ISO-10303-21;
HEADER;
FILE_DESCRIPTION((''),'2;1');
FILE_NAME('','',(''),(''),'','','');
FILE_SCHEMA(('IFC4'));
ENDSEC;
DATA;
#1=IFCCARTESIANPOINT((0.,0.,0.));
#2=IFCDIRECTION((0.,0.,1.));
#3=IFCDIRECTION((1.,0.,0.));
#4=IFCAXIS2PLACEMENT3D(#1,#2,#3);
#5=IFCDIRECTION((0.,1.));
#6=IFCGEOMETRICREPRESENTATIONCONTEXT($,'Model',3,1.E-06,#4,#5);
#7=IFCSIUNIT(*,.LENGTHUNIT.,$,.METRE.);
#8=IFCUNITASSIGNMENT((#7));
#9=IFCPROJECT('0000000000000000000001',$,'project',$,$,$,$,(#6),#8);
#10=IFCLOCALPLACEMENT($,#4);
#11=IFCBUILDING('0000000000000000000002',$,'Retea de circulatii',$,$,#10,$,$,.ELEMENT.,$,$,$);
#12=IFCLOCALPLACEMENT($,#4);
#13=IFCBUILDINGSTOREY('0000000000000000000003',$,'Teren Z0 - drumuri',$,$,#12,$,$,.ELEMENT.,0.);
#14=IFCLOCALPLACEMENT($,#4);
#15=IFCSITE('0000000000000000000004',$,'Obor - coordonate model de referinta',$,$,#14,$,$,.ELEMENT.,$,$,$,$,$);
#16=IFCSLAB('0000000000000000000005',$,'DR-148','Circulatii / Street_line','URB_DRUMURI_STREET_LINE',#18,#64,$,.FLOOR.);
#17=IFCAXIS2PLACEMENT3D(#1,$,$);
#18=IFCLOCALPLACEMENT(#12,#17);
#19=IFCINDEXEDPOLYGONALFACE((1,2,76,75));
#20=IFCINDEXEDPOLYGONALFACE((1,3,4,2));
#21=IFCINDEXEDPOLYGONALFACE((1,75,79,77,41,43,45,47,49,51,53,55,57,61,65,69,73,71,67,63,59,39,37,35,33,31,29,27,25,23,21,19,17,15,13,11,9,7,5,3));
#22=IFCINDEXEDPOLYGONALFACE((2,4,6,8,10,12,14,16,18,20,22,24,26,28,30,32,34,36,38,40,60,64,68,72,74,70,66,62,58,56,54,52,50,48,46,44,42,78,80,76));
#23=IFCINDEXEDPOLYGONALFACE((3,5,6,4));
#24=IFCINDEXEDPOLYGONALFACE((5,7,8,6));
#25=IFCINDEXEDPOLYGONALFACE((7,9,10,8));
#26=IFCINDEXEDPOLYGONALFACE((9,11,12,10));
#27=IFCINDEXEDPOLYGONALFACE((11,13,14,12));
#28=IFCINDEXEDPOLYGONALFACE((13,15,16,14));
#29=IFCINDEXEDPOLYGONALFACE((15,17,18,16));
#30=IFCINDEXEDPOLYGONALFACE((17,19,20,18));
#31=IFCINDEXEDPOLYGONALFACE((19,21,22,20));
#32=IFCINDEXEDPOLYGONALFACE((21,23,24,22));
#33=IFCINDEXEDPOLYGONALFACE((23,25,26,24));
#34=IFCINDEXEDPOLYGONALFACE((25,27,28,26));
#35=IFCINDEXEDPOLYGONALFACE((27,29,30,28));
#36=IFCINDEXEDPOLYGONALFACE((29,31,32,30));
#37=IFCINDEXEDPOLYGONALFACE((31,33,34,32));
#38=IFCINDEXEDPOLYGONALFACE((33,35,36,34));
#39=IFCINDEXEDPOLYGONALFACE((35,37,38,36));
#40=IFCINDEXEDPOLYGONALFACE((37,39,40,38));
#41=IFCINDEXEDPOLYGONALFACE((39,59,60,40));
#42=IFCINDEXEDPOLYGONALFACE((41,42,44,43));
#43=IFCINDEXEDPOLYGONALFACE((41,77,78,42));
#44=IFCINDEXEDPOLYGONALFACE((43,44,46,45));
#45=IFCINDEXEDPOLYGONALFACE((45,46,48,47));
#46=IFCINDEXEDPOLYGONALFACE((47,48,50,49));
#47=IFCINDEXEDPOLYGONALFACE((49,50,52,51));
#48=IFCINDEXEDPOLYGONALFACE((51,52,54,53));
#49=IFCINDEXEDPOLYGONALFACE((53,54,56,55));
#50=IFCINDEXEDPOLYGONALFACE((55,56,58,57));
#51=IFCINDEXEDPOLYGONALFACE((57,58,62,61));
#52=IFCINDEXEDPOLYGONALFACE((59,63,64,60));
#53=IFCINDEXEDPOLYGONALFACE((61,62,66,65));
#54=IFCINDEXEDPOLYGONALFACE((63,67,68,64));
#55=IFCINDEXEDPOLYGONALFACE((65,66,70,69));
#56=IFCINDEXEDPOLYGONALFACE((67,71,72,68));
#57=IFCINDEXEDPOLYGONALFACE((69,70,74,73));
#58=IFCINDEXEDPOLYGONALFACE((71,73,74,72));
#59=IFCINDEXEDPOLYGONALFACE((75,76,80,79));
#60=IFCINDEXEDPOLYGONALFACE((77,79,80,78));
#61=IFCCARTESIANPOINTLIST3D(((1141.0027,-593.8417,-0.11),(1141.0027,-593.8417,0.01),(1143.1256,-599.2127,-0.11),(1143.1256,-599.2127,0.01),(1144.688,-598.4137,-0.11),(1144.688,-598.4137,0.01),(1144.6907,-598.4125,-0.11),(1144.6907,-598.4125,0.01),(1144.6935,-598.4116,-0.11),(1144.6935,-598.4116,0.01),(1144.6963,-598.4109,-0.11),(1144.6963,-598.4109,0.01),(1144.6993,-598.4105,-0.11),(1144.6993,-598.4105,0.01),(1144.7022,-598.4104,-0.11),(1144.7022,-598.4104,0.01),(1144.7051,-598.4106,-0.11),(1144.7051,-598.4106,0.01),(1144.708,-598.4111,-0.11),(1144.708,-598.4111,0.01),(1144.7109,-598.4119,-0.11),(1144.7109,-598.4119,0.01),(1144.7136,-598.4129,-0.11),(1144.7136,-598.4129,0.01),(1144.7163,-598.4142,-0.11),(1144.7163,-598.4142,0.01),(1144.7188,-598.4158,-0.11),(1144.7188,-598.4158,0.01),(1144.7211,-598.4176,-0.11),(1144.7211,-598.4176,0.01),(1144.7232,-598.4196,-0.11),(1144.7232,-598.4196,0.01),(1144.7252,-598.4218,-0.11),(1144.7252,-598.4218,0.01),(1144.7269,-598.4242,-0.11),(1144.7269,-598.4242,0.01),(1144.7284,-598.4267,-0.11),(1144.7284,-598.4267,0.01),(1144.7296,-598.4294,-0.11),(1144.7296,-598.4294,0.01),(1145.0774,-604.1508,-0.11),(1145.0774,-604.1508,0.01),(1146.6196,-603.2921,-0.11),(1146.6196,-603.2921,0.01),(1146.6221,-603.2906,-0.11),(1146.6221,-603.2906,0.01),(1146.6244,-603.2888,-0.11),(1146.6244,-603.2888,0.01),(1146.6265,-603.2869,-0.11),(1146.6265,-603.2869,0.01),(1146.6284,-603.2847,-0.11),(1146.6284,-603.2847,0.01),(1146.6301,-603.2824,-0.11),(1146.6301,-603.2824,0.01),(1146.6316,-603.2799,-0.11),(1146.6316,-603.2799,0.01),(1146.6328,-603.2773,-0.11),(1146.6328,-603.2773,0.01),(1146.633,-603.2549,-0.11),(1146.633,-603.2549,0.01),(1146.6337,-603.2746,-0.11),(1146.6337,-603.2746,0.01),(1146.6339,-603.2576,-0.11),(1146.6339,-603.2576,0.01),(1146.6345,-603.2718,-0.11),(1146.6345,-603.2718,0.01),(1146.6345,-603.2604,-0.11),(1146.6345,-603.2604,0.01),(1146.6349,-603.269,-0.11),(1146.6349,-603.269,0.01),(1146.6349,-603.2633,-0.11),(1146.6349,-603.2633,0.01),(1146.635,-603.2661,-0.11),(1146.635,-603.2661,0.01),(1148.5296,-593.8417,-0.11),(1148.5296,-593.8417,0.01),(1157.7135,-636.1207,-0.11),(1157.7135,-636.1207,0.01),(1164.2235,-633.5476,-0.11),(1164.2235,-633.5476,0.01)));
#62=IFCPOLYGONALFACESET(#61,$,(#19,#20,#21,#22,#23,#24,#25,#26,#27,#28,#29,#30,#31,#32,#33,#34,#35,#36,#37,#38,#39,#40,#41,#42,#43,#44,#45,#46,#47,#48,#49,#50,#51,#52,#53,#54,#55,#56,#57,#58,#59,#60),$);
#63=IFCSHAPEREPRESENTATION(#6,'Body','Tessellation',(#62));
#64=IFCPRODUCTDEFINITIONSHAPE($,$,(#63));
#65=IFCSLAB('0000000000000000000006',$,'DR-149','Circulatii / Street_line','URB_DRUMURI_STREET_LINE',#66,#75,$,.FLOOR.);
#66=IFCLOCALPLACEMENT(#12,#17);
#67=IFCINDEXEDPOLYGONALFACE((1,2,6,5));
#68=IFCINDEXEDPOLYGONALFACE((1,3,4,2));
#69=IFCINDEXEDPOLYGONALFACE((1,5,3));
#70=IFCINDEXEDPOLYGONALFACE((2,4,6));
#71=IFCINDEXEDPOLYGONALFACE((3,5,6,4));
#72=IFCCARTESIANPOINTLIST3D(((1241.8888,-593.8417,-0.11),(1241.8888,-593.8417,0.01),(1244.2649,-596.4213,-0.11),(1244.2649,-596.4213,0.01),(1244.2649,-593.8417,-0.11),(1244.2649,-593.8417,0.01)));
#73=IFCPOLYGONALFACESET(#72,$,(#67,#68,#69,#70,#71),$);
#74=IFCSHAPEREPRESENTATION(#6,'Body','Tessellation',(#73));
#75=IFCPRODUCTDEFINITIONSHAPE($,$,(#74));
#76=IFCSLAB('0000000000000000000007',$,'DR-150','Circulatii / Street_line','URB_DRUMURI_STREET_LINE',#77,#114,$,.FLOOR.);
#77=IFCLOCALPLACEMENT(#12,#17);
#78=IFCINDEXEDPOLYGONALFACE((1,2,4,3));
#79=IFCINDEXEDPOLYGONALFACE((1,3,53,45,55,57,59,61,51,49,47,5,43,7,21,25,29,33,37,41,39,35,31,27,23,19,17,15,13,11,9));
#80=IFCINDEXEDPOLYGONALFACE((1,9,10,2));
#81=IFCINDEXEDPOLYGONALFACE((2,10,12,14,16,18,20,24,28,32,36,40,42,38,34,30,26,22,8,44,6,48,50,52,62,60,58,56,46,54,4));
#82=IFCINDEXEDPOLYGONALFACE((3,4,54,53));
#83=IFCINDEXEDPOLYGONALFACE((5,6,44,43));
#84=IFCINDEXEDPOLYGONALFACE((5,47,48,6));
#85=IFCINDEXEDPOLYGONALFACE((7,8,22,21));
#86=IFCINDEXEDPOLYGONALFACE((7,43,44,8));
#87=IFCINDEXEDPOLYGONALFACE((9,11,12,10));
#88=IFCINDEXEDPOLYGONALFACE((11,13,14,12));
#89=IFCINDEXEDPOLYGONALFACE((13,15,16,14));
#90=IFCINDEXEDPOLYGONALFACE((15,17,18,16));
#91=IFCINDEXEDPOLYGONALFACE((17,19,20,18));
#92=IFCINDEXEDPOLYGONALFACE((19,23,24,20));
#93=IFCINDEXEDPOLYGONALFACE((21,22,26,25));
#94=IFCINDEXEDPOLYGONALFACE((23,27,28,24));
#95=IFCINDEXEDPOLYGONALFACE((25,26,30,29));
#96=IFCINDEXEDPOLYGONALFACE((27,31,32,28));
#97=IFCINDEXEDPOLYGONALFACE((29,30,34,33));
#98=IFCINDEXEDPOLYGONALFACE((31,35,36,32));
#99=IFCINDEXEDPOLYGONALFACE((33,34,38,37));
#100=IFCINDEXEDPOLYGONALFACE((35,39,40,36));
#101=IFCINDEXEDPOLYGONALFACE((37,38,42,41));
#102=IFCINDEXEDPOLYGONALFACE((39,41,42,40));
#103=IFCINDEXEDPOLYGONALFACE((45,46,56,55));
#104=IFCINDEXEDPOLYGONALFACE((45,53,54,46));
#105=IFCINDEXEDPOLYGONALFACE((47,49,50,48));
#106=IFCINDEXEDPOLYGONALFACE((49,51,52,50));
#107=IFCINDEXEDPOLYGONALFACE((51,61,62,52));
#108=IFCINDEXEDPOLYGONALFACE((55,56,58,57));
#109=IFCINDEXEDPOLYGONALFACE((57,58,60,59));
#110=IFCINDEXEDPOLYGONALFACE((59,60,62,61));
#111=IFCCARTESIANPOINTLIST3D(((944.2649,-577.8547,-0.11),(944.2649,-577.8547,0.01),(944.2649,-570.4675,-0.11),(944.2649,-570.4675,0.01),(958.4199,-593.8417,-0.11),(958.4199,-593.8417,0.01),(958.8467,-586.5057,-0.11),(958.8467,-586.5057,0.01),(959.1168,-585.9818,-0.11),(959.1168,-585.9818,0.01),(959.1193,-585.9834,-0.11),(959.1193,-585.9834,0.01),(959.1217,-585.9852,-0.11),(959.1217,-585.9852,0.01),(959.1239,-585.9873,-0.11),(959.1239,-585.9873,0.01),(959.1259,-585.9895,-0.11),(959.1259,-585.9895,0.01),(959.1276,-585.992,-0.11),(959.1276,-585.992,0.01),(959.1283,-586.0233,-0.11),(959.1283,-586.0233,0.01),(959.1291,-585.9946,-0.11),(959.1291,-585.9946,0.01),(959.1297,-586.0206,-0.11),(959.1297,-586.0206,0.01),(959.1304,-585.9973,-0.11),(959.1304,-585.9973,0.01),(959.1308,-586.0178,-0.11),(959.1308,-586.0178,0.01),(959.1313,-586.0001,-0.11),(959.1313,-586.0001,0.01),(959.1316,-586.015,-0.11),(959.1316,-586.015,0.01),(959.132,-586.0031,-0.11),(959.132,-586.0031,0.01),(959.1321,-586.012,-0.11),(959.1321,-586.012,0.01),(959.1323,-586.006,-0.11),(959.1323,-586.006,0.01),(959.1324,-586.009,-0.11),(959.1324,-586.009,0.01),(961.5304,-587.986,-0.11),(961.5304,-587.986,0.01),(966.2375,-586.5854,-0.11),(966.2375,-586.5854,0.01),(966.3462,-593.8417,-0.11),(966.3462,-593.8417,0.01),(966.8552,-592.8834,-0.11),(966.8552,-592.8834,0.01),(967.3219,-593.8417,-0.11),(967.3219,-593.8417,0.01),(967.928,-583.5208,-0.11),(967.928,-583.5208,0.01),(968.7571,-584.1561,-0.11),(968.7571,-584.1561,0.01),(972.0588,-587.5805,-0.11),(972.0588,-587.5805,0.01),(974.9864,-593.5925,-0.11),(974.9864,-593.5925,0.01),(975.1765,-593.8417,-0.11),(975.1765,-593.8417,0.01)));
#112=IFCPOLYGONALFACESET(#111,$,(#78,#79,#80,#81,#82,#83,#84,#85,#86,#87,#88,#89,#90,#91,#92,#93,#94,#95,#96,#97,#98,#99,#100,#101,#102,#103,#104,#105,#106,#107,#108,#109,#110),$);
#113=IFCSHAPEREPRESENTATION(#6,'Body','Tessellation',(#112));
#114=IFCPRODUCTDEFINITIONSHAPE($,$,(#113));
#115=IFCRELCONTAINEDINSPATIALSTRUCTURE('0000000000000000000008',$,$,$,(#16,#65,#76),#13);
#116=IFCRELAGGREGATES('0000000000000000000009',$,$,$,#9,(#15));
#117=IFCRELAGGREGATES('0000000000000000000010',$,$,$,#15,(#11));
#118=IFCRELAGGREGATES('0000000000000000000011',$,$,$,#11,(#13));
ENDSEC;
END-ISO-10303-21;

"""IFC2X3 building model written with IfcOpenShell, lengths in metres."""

from ifc_helpers import new_model, si_unit, direction, frame, origin_with_axes, place, context, project, spatial, polyline, outline, extrude, element, save


model = new_model("IFC2X3")

# Units and contexts
model_context = context("Model", 3, precision=1e-06, world=origin_with_axes(), true_north=direction((0.0, 1.0)))
ifc_project = project(units=[si_unit("LENGTHUNIT", "METRE")], contexts=[model_context])

# Site, building, storey
site_placement = place(None, origin_with_axes())
site = spatial("IfcSite", under=ifc_project, at=site_placement, Name="Obor - coordonate model de referinta", CompositionType="ELEMENT")
building_placement = place(None, origin_with_axes())
building = spatial("IfcBuilding", under=site, at=building_placement, Name="Retea de circulatii", CompositionType="ELEMENT")
storey_placement = place(None, origin_with_axes())
storey = spatial("IfcBuildingStorey", under=building, at=storey_placement, Name="Teren Z0 - drumuri", CompositionType="ELEMENT", Elevation=0.0)

# Slabs
slab_1_placement = place(None, origin_with_axes())
element("IfcSlab", 1, at=slab_1_placement, inside=storey, Name="DR-148", Description="Circulatii / Street_line", ObjectType="URB_DRUMURI_STREET_LINE", PredefinedType="FLOOR", context=model_context, shape_type="SweptSolid", body=[
    extrude(outline(polyline([(1146.6221, -603.2906), (1146.6196, -603.2921), (1145.0774, -604.1508), (1157.7135, -636.1207), (1164.2235, -633.5476), (1148.5296, -593.8417), (1141.0027, -593.8417), (1143.1256, -599.2127), (1144.688, -598.4137), (1144.6907, -598.4125), (1144.6935, -598.4116), (1144.6963, -598.4109), (1144.6993, -598.4105), (1144.7022, -598.4104), (1144.7051, -598.4106), (1144.708, -598.4111), (1144.7109, -598.4119), (1144.7136, -598.4129), (1144.7163, -598.4142), (1144.7188, -598.4158), (1144.7211, -598.4176), (1144.7232, -598.4196), (1144.7252, -598.4218), (1144.7269, -598.4242), (1144.7284, -598.4267), (1144.7296, -598.4294), (1146.633, -603.2549), (1146.6339, -603.2576), (1146.6345, -603.2604), (1146.6349, -603.2633), (1146.635, -603.2661), (1146.6349, -603.269), (1146.6345, -603.2718), (1146.6337, -603.2746), (1146.6328, -603.2773), (1146.6316, -603.2799), (1146.6301, -603.2824), (1146.6284, -603.2847), (1146.6265, -603.2869), (1146.6244, -603.2888), (1146.6221, -603.2906)])), frame((0.0, 0.0, -0.11), z_axis=(0.0, 0.0, 1.0), x_axis=(1.0, 0.0, 0.0)), (0.0, 0.0, 1.0), 0.12),
])
slab_2_placement = place(None, origin_with_axes())
element("IfcSlab", 2, at=slab_2_placement, inside=storey, Name="DR-149", Description="Circulatii / Street_line", ObjectType="URB_DRUMURI_STREET_LINE", PredefinedType="FLOOR", context=model_context, shape_type="SweptSolid", body=[
    extrude(outline(polyline([(1244.2649, -593.8417), (1241.8888, -593.8417), (1244.2649, -596.4213), (1244.2649, -593.8417)])), frame((0.0, 0.0, -0.11), z_axis=(0.0, 0.0, 1.0), x_axis=(1.0, 0.0, 0.0)), (0.0, 0.0, 1.0), 0.12),
])
slab_3_placement = place(None, origin_with_axes())
element("IfcSlab", 3, at=slab_3_placement, inside=storey, Name="DR-150", Description="Circulatii / Street_line", ObjectType="URB_DRUMURI_STREET_LINE", PredefinedType="FLOOR", context=model_context, shape_type="SweptSolid", body=[
    extrude(outline(polyline([(972.0588, -587.5805), (968.7571, -584.1561), (966.2375, -586.5854), (967.928, -583.5208), (944.2649, -570.4675), (944.2649, -577.8547), (959.1168, -585.9818), (959.1193, -585.9834), (959.1217, -585.9852), (959.1239, -585.9873), (959.1259, -585.9895), (959.1276, -585.992), (959.1291, -585.9946), (959.1304, -585.9973), (959.1313, -586.0001), (959.132, -586.0031), (959.1323, -586.006), (959.1324, -586.009), (959.1321, -586.012), (959.1316, -586.015), (959.1308, -586.0178), (959.1297, -586.0206), (959.1283, -586.0233), (958.8467, -586.5057), (961.5304, -587.986), (958.4199, -593.8417), (966.3462, -593.8417), (966.8552, -592.8834), (967.3219, -593.8417), (975.1765, -593.8417), (974.9864, -593.5925), (972.0588, -587.5805)])), frame((0.0, 0.0, -0.11), z_axis=(0.0, 0.0, 1.0), x_axis=(1.0, 0.0, 0.0)), (0.0, 0.0, 1.0), 0.12),
])

save(model, "model.ifc")
